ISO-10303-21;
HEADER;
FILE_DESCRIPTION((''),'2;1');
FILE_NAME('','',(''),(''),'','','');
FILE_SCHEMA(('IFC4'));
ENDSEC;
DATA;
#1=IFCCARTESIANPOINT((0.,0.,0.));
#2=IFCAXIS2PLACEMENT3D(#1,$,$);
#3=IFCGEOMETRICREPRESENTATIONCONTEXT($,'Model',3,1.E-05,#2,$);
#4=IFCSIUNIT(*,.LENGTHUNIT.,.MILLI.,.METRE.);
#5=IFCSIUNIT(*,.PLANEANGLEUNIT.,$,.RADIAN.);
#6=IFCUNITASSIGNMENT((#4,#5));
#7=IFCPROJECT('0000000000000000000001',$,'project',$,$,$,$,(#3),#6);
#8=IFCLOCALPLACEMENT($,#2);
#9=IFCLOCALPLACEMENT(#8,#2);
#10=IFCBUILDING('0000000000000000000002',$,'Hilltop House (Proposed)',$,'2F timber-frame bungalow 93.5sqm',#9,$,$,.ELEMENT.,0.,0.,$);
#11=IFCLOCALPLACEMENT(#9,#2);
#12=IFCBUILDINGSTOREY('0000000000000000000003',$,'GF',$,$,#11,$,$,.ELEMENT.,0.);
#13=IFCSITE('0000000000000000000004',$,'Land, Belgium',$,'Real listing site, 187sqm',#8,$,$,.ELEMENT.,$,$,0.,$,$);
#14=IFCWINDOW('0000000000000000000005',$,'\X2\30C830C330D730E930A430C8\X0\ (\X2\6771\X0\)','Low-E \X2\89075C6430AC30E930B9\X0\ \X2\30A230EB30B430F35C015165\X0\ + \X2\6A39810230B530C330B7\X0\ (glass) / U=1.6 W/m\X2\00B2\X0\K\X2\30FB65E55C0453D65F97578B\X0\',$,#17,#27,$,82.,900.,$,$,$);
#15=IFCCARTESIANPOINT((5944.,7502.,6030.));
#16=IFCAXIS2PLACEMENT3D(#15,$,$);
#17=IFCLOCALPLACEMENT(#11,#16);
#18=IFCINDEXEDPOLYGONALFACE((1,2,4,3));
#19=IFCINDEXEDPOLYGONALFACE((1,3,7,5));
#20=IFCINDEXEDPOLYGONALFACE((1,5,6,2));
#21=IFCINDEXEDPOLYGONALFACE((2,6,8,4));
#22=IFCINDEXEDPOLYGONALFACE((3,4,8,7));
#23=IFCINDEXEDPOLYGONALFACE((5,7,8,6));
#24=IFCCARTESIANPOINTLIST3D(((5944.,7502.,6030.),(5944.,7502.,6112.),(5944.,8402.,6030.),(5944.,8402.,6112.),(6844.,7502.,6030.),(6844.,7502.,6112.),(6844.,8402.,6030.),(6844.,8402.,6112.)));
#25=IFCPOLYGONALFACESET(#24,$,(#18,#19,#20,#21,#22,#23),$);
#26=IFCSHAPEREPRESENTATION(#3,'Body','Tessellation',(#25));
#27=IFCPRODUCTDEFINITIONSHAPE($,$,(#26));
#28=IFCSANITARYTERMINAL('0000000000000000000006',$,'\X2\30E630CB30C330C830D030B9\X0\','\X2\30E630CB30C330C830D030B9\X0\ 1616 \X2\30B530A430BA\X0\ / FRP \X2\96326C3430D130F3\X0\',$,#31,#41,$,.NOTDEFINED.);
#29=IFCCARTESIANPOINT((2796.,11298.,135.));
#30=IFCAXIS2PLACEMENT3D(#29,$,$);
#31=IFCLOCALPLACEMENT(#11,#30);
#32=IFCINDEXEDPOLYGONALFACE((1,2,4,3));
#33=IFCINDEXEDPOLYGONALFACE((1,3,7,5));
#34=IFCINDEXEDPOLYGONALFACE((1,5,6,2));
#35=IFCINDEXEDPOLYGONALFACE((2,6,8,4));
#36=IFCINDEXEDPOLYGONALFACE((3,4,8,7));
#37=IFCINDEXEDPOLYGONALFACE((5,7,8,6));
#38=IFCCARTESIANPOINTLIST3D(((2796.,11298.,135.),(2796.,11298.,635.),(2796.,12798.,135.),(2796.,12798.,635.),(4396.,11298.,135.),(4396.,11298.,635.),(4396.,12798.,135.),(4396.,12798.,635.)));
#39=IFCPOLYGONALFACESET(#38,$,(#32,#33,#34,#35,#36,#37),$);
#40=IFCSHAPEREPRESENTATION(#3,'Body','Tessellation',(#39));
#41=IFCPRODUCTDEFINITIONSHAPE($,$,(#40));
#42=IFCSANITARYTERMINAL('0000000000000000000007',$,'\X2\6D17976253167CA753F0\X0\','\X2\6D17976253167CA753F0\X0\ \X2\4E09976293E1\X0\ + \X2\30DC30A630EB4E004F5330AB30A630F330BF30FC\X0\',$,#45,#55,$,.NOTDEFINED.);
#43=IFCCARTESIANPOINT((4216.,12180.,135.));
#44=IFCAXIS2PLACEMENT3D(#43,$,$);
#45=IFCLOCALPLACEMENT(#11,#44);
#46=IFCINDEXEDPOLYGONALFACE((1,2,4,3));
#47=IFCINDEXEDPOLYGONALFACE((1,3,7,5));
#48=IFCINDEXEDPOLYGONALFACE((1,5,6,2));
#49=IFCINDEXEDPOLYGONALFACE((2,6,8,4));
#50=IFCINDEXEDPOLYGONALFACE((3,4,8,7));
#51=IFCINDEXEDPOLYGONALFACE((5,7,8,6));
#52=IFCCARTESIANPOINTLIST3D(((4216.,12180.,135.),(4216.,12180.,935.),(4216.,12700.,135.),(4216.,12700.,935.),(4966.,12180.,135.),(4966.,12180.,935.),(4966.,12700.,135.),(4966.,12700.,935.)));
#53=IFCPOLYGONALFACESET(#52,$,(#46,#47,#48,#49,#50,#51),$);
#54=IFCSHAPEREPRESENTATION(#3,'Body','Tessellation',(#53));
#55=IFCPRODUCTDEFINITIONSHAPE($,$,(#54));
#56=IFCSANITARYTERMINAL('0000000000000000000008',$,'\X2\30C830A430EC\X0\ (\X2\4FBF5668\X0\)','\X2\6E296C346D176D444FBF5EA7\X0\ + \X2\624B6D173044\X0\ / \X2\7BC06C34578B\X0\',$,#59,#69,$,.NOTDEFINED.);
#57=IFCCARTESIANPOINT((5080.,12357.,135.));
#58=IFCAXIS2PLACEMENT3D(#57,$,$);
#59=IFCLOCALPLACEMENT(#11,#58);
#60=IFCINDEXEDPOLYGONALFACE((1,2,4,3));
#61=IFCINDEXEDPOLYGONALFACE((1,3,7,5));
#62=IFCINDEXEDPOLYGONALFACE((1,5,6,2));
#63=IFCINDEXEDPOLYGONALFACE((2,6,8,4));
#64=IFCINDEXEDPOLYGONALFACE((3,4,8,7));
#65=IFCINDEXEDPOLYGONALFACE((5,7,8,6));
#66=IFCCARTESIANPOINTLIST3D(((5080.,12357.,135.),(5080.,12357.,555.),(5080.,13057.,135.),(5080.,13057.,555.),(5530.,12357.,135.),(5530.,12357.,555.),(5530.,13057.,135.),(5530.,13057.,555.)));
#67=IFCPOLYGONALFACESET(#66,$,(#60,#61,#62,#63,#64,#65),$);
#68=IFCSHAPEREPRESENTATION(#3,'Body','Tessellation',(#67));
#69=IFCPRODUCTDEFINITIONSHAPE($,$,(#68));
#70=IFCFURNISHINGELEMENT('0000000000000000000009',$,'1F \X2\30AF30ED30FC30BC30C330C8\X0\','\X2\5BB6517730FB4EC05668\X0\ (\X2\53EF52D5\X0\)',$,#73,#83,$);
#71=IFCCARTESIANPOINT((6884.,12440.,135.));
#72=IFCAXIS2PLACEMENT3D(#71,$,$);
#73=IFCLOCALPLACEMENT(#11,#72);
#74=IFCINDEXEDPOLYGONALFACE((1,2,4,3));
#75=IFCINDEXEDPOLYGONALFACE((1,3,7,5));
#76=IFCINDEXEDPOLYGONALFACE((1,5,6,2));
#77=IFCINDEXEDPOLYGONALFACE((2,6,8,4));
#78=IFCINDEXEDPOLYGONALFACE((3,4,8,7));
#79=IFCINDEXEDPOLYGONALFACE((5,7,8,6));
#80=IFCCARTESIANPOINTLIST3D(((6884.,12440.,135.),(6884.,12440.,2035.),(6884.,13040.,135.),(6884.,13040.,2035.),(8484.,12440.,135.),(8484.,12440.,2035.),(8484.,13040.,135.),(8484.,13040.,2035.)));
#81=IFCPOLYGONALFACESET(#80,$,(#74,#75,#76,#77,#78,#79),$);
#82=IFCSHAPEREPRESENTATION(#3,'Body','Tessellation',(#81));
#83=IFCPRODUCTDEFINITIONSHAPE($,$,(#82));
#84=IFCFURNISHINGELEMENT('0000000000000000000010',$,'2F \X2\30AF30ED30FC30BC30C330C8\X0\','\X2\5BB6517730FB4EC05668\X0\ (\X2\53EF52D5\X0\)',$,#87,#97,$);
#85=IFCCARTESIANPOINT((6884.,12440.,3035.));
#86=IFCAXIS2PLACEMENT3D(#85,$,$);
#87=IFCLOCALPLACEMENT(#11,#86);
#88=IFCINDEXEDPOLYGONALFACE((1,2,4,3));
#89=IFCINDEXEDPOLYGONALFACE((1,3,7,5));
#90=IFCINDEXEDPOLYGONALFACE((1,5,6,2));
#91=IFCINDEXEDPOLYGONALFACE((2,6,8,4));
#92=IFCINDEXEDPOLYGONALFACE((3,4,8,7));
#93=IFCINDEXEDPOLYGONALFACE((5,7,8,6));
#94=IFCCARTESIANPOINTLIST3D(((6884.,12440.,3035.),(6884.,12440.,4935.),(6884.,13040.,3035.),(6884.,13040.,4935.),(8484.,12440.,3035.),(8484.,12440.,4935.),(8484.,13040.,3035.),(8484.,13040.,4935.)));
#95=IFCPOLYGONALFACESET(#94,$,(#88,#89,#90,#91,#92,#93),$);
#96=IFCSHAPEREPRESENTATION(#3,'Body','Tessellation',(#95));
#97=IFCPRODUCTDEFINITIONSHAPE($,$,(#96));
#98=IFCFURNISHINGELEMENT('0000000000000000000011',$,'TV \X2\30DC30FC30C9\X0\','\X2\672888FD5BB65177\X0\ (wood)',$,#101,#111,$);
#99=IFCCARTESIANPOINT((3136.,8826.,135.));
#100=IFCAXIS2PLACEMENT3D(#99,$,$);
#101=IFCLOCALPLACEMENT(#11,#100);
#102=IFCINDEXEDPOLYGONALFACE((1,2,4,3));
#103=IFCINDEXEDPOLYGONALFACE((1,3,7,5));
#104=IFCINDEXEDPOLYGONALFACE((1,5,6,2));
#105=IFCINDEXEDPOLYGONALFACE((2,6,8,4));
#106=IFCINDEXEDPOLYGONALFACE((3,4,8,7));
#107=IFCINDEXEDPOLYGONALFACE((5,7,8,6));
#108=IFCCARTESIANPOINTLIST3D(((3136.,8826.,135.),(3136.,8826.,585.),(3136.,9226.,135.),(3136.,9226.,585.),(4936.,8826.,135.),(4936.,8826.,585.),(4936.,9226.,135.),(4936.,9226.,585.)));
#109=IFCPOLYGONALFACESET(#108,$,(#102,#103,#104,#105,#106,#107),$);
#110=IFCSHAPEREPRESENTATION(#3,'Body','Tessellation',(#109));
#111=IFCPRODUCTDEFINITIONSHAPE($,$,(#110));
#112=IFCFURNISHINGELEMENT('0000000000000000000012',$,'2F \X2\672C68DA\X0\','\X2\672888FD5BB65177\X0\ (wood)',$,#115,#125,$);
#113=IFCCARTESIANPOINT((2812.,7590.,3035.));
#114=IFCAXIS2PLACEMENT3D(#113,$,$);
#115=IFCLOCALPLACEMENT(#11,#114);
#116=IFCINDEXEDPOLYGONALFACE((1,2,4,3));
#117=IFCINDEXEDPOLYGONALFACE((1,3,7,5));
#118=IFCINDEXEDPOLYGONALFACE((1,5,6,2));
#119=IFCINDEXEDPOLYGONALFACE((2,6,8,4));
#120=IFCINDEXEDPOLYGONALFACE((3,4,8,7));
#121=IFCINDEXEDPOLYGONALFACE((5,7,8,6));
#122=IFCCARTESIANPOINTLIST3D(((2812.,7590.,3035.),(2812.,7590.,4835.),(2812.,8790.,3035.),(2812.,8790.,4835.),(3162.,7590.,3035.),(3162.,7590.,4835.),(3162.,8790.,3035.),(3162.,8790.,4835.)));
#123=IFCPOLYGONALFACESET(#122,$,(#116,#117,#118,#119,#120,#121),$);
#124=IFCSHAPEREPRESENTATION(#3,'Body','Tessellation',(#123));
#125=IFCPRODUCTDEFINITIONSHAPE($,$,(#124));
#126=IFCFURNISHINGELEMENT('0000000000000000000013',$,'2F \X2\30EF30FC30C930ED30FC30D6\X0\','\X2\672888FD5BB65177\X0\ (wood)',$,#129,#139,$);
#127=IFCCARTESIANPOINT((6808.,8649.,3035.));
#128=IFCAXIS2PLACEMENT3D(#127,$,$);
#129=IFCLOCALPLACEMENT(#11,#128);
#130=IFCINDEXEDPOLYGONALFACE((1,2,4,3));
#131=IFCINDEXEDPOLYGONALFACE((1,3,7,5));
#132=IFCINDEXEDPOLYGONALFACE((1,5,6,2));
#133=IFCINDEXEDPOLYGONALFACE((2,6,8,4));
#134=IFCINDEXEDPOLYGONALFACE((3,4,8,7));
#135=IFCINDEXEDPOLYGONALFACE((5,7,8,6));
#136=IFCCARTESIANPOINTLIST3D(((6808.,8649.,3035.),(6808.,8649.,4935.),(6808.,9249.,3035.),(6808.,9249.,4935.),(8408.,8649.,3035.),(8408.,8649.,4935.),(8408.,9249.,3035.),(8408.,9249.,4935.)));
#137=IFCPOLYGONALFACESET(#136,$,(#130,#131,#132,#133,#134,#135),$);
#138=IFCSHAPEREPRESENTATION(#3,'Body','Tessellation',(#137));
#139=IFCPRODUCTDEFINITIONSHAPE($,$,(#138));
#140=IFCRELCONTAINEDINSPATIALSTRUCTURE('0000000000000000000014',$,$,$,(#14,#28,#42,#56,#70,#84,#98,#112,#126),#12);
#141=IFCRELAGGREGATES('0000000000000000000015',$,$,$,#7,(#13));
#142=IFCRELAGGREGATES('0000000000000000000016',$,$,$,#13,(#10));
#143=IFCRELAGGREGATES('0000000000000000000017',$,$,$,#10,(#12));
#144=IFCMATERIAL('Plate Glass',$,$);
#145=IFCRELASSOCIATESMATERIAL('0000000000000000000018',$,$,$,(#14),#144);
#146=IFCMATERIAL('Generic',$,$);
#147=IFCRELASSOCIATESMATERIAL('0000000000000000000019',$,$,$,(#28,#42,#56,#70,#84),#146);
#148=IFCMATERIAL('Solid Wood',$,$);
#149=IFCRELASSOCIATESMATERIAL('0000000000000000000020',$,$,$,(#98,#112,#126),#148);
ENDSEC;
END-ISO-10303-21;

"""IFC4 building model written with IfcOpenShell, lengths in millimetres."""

from ifc_helpers import new_model, si_unit, frame, frame_2d, origin, place, context, project, spatial, rectangle, extrude, material, element, save


model = new_model("IFC4")

# Units and contexts
model_context = context("Model", 3, precision=1e-05, world=origin())
ifc_project = project(units=[si_unit("LENGTHUNIT", "METRE", prefix="MILLI"), si_unit("PLANEANGLEUNIT", "RADIAN")], contexts=[model_context])

# Site, building, storey
site_placement = place(None, origin())
site = spatial("IfcSite", under=ifc_project, at=site_placement, Name="Land, Belgium", ObjectType="Real listing site, 187sqm", CompositionType="ELEMENT", RefElevation=0.0)
building_placement = place(site_placement, origin())
building = spatial("IfcBuilding", under=site, at=building_placement, Name="Hilltop House (Proposed)", ObjectType="2F timber-frame bungalow 93.5sqm", CompositionType="ELEMENT", ElevationOfRefHeight=0.0, ElevationOfTerrain=0.0)
storey_placement = place(building_placement, origin())
storey = spatial("IfcBuildingStorey", under=building, at=storey_placement, Name="GF", CompositionType="ELEMENT", Elevation=0.0)

# Shared definitions
ifc_material_1 = material(Name="Solid Wood")
ifc_material_2 = material(Name="Plate Glass")

# Window
window_1_placement = place(storey_placement, frame((5944.0, 7502.0, 6030.0)))
element("IfcWindow", 1, at=window_1_placement, inside=storey, material=ifc_material_2, Name="トップライト (東)", Description="Low-E 複層ガラス アルゴン封入 + 樹脂サッシ (glass) / U=1.6 W/m²K・日射取得型", OverallHeight=82.0, OverallWidth=900.0, context=model_context, shape_type="SweptSolid", body=[
    extrude(rectangle(XDim=900.0, YDim=900.0, at=frame_2d((450.0, 450.0))), frame((5944.0, 7502.0, 6030.0)), (0.0, 0.0, 1.0), 82.0),
])

# Sanitary terminals
ifc_material_3 = material(Name="Generic")
sanitary_terminal_1_placement = place(storey_placement, frame((2796.0, 11298.0, 135.0)))
element("IfcSanitaryTerminal", 2, at=sanitary_terminal_1_placement, inside=storey, material=ifc_material_3, Name="ユニットバス", Description="ユニットバス 1616 サイズ / FRP 防水パン", PredefinedType="NOTDEFINED", context=model_context, shape_type="SweptSolid", body=[
    extrude(rectangle(XDim=1600.0, YDim=1500.0, at=frame_2d((800.0, 750.0))), frame((2796.0, 11298.0, 135.0)), (0.0, 0.0, 1.0), 500.0),
])
sanitary_terminal_2_placement = place(storey_placement, frame((4216.0, 12180.0, 135.0)))
element("IfcSanitaryTerminal", 3, at=sanitary_terminal_2_placement, inside=storey, material=ifc_material_3, Name="洗面化粧台", Description="洗面化粧台 三面鏡 + ボウル一体カウンター", PredefinedType="NOTDEFINED", context=model_context, shape_type="SweptSolid", body=[
    extrude(rectangle(XDim=750.0, YDim=520.0, at=frame_2d((375.0, 260.0))), frame((4216.0, 12180.0, 135.0)), (0.0, 0.0, 1.0), 800.0),
])
sanitary_terminal_3_placement = place(storey_placement, frame((5080.0, 12357.0, 135.0)))
element("IfcSanitaryTerminal", 4, at=sanitary_terminal_3_placement, inside=storey, material=ifc_material_3, Name="トイレ (便器)", Description="温水洗浄便座 + 手洗い / 節水型", PredefinedType="NOTDEFINED", context=model_context, shape_type="SweptSolid", body=[
    extrude(rectangle(XDim=450.0, YDim=700.0, at=frame_2d((225.0, 350.0))), frame((5080.0, 12357.0, 135.0)), (0.0, 0.0, 1.0), 420.0),
])

# Furnishing elements
furnishing_1_placement = place(storey_placement, frame((6884.0, 12440.0, 135.0)))
element("IfcFurnishingElement", 5, at=furnishing_1_placement, inside=storey, material=ifc_material_3, Name="1F クローゼット", Description="家具・什器 (可動)", context=model_context, shape_type="SweptSolid", body=[
    extrude(rectangle(XDim=1600.0, YDim=600.0, at=frame_2d((800.0, 300.0))), frame((6884.0, 12440.0, 135.0)), (0.0, 0.0, 1.0), 1900.0),
])
furnishing_2_placement = place(storey_placement, frame((6884.0, 12440.0, 3035.0)))
element("IfcFurnishingElement", 6, at=furnishing_2_placement, inside=storey, material=ifc_material_3, Name="2F クローゼット", Description="家具・什器 (可動)", context=model_context, shape_type="SweptSolid", body=[
    extrude(rectangle(XDim=1600.0, YDim=600.0, at=frame_2d((800.0, 300.0))), frame((6884.0, 12440.0, 3035.0)), (0.0, 0.0, 1.0), 1900.0),
])
furnishing_3_placement = place(storey_placement, frame((3136.0, 8826.0, 135.0)))
element("IfcFurnishingElement", 7, at=furnishing_3_placement, inside=storey, material=ifc_material_1, Name="TV ボード", Description="木製家具 (wood)", context=model_context, shape_type="SweptSolid", body=[
    extrude(rectangle(XDim=1800.0, YDim=400.0, at=frame_2d((900.0, 200.0))), frame((3136.0, 8826.0, 135.0)), (0.0, 0.0, 1.0), 450.0),
])
furnishing_4_placement = place(storey_placement, frame((2812.0, 7590.0, 3035.0)))
element("IfcFurnishingElement", 8, at=furnishing_4_placement, inside=storey, material=ifc_material_1, Name="2F 本棚", Description="木製家具 (wood)", context=model_context, shape_type="SweptSolid", body=[
    extrude(rectangle(XDim=350.0, YDim=1200.0, at=frame_2d((175.0, 600.0))), frame((2812.0, 7590.0, 3035.0)), (0.0, 0.0, 1.0), 1800.0),
])
furnishing_5_placement = place(storey_placement, frame((6808.0, 8649.0, 3035.0)))
element("IfcFurnishingElement", 9, at=furnishing_5_placement, inside=storey, material=ifc_material_1, Name="2F ワードローブ", Description="木製家具 (wood)", context=model_context, shape_type="SweptSolid", body=[
    extrude(rectangle(XDim=1600.0, YDim=600.0, at=frame_2d((800.0, 300.0))), frame((6808.0, 8649.0, 3035.0)), (0.0, 0.0, 1.0), 1900.0),
])

save(model, "model.ifc")
